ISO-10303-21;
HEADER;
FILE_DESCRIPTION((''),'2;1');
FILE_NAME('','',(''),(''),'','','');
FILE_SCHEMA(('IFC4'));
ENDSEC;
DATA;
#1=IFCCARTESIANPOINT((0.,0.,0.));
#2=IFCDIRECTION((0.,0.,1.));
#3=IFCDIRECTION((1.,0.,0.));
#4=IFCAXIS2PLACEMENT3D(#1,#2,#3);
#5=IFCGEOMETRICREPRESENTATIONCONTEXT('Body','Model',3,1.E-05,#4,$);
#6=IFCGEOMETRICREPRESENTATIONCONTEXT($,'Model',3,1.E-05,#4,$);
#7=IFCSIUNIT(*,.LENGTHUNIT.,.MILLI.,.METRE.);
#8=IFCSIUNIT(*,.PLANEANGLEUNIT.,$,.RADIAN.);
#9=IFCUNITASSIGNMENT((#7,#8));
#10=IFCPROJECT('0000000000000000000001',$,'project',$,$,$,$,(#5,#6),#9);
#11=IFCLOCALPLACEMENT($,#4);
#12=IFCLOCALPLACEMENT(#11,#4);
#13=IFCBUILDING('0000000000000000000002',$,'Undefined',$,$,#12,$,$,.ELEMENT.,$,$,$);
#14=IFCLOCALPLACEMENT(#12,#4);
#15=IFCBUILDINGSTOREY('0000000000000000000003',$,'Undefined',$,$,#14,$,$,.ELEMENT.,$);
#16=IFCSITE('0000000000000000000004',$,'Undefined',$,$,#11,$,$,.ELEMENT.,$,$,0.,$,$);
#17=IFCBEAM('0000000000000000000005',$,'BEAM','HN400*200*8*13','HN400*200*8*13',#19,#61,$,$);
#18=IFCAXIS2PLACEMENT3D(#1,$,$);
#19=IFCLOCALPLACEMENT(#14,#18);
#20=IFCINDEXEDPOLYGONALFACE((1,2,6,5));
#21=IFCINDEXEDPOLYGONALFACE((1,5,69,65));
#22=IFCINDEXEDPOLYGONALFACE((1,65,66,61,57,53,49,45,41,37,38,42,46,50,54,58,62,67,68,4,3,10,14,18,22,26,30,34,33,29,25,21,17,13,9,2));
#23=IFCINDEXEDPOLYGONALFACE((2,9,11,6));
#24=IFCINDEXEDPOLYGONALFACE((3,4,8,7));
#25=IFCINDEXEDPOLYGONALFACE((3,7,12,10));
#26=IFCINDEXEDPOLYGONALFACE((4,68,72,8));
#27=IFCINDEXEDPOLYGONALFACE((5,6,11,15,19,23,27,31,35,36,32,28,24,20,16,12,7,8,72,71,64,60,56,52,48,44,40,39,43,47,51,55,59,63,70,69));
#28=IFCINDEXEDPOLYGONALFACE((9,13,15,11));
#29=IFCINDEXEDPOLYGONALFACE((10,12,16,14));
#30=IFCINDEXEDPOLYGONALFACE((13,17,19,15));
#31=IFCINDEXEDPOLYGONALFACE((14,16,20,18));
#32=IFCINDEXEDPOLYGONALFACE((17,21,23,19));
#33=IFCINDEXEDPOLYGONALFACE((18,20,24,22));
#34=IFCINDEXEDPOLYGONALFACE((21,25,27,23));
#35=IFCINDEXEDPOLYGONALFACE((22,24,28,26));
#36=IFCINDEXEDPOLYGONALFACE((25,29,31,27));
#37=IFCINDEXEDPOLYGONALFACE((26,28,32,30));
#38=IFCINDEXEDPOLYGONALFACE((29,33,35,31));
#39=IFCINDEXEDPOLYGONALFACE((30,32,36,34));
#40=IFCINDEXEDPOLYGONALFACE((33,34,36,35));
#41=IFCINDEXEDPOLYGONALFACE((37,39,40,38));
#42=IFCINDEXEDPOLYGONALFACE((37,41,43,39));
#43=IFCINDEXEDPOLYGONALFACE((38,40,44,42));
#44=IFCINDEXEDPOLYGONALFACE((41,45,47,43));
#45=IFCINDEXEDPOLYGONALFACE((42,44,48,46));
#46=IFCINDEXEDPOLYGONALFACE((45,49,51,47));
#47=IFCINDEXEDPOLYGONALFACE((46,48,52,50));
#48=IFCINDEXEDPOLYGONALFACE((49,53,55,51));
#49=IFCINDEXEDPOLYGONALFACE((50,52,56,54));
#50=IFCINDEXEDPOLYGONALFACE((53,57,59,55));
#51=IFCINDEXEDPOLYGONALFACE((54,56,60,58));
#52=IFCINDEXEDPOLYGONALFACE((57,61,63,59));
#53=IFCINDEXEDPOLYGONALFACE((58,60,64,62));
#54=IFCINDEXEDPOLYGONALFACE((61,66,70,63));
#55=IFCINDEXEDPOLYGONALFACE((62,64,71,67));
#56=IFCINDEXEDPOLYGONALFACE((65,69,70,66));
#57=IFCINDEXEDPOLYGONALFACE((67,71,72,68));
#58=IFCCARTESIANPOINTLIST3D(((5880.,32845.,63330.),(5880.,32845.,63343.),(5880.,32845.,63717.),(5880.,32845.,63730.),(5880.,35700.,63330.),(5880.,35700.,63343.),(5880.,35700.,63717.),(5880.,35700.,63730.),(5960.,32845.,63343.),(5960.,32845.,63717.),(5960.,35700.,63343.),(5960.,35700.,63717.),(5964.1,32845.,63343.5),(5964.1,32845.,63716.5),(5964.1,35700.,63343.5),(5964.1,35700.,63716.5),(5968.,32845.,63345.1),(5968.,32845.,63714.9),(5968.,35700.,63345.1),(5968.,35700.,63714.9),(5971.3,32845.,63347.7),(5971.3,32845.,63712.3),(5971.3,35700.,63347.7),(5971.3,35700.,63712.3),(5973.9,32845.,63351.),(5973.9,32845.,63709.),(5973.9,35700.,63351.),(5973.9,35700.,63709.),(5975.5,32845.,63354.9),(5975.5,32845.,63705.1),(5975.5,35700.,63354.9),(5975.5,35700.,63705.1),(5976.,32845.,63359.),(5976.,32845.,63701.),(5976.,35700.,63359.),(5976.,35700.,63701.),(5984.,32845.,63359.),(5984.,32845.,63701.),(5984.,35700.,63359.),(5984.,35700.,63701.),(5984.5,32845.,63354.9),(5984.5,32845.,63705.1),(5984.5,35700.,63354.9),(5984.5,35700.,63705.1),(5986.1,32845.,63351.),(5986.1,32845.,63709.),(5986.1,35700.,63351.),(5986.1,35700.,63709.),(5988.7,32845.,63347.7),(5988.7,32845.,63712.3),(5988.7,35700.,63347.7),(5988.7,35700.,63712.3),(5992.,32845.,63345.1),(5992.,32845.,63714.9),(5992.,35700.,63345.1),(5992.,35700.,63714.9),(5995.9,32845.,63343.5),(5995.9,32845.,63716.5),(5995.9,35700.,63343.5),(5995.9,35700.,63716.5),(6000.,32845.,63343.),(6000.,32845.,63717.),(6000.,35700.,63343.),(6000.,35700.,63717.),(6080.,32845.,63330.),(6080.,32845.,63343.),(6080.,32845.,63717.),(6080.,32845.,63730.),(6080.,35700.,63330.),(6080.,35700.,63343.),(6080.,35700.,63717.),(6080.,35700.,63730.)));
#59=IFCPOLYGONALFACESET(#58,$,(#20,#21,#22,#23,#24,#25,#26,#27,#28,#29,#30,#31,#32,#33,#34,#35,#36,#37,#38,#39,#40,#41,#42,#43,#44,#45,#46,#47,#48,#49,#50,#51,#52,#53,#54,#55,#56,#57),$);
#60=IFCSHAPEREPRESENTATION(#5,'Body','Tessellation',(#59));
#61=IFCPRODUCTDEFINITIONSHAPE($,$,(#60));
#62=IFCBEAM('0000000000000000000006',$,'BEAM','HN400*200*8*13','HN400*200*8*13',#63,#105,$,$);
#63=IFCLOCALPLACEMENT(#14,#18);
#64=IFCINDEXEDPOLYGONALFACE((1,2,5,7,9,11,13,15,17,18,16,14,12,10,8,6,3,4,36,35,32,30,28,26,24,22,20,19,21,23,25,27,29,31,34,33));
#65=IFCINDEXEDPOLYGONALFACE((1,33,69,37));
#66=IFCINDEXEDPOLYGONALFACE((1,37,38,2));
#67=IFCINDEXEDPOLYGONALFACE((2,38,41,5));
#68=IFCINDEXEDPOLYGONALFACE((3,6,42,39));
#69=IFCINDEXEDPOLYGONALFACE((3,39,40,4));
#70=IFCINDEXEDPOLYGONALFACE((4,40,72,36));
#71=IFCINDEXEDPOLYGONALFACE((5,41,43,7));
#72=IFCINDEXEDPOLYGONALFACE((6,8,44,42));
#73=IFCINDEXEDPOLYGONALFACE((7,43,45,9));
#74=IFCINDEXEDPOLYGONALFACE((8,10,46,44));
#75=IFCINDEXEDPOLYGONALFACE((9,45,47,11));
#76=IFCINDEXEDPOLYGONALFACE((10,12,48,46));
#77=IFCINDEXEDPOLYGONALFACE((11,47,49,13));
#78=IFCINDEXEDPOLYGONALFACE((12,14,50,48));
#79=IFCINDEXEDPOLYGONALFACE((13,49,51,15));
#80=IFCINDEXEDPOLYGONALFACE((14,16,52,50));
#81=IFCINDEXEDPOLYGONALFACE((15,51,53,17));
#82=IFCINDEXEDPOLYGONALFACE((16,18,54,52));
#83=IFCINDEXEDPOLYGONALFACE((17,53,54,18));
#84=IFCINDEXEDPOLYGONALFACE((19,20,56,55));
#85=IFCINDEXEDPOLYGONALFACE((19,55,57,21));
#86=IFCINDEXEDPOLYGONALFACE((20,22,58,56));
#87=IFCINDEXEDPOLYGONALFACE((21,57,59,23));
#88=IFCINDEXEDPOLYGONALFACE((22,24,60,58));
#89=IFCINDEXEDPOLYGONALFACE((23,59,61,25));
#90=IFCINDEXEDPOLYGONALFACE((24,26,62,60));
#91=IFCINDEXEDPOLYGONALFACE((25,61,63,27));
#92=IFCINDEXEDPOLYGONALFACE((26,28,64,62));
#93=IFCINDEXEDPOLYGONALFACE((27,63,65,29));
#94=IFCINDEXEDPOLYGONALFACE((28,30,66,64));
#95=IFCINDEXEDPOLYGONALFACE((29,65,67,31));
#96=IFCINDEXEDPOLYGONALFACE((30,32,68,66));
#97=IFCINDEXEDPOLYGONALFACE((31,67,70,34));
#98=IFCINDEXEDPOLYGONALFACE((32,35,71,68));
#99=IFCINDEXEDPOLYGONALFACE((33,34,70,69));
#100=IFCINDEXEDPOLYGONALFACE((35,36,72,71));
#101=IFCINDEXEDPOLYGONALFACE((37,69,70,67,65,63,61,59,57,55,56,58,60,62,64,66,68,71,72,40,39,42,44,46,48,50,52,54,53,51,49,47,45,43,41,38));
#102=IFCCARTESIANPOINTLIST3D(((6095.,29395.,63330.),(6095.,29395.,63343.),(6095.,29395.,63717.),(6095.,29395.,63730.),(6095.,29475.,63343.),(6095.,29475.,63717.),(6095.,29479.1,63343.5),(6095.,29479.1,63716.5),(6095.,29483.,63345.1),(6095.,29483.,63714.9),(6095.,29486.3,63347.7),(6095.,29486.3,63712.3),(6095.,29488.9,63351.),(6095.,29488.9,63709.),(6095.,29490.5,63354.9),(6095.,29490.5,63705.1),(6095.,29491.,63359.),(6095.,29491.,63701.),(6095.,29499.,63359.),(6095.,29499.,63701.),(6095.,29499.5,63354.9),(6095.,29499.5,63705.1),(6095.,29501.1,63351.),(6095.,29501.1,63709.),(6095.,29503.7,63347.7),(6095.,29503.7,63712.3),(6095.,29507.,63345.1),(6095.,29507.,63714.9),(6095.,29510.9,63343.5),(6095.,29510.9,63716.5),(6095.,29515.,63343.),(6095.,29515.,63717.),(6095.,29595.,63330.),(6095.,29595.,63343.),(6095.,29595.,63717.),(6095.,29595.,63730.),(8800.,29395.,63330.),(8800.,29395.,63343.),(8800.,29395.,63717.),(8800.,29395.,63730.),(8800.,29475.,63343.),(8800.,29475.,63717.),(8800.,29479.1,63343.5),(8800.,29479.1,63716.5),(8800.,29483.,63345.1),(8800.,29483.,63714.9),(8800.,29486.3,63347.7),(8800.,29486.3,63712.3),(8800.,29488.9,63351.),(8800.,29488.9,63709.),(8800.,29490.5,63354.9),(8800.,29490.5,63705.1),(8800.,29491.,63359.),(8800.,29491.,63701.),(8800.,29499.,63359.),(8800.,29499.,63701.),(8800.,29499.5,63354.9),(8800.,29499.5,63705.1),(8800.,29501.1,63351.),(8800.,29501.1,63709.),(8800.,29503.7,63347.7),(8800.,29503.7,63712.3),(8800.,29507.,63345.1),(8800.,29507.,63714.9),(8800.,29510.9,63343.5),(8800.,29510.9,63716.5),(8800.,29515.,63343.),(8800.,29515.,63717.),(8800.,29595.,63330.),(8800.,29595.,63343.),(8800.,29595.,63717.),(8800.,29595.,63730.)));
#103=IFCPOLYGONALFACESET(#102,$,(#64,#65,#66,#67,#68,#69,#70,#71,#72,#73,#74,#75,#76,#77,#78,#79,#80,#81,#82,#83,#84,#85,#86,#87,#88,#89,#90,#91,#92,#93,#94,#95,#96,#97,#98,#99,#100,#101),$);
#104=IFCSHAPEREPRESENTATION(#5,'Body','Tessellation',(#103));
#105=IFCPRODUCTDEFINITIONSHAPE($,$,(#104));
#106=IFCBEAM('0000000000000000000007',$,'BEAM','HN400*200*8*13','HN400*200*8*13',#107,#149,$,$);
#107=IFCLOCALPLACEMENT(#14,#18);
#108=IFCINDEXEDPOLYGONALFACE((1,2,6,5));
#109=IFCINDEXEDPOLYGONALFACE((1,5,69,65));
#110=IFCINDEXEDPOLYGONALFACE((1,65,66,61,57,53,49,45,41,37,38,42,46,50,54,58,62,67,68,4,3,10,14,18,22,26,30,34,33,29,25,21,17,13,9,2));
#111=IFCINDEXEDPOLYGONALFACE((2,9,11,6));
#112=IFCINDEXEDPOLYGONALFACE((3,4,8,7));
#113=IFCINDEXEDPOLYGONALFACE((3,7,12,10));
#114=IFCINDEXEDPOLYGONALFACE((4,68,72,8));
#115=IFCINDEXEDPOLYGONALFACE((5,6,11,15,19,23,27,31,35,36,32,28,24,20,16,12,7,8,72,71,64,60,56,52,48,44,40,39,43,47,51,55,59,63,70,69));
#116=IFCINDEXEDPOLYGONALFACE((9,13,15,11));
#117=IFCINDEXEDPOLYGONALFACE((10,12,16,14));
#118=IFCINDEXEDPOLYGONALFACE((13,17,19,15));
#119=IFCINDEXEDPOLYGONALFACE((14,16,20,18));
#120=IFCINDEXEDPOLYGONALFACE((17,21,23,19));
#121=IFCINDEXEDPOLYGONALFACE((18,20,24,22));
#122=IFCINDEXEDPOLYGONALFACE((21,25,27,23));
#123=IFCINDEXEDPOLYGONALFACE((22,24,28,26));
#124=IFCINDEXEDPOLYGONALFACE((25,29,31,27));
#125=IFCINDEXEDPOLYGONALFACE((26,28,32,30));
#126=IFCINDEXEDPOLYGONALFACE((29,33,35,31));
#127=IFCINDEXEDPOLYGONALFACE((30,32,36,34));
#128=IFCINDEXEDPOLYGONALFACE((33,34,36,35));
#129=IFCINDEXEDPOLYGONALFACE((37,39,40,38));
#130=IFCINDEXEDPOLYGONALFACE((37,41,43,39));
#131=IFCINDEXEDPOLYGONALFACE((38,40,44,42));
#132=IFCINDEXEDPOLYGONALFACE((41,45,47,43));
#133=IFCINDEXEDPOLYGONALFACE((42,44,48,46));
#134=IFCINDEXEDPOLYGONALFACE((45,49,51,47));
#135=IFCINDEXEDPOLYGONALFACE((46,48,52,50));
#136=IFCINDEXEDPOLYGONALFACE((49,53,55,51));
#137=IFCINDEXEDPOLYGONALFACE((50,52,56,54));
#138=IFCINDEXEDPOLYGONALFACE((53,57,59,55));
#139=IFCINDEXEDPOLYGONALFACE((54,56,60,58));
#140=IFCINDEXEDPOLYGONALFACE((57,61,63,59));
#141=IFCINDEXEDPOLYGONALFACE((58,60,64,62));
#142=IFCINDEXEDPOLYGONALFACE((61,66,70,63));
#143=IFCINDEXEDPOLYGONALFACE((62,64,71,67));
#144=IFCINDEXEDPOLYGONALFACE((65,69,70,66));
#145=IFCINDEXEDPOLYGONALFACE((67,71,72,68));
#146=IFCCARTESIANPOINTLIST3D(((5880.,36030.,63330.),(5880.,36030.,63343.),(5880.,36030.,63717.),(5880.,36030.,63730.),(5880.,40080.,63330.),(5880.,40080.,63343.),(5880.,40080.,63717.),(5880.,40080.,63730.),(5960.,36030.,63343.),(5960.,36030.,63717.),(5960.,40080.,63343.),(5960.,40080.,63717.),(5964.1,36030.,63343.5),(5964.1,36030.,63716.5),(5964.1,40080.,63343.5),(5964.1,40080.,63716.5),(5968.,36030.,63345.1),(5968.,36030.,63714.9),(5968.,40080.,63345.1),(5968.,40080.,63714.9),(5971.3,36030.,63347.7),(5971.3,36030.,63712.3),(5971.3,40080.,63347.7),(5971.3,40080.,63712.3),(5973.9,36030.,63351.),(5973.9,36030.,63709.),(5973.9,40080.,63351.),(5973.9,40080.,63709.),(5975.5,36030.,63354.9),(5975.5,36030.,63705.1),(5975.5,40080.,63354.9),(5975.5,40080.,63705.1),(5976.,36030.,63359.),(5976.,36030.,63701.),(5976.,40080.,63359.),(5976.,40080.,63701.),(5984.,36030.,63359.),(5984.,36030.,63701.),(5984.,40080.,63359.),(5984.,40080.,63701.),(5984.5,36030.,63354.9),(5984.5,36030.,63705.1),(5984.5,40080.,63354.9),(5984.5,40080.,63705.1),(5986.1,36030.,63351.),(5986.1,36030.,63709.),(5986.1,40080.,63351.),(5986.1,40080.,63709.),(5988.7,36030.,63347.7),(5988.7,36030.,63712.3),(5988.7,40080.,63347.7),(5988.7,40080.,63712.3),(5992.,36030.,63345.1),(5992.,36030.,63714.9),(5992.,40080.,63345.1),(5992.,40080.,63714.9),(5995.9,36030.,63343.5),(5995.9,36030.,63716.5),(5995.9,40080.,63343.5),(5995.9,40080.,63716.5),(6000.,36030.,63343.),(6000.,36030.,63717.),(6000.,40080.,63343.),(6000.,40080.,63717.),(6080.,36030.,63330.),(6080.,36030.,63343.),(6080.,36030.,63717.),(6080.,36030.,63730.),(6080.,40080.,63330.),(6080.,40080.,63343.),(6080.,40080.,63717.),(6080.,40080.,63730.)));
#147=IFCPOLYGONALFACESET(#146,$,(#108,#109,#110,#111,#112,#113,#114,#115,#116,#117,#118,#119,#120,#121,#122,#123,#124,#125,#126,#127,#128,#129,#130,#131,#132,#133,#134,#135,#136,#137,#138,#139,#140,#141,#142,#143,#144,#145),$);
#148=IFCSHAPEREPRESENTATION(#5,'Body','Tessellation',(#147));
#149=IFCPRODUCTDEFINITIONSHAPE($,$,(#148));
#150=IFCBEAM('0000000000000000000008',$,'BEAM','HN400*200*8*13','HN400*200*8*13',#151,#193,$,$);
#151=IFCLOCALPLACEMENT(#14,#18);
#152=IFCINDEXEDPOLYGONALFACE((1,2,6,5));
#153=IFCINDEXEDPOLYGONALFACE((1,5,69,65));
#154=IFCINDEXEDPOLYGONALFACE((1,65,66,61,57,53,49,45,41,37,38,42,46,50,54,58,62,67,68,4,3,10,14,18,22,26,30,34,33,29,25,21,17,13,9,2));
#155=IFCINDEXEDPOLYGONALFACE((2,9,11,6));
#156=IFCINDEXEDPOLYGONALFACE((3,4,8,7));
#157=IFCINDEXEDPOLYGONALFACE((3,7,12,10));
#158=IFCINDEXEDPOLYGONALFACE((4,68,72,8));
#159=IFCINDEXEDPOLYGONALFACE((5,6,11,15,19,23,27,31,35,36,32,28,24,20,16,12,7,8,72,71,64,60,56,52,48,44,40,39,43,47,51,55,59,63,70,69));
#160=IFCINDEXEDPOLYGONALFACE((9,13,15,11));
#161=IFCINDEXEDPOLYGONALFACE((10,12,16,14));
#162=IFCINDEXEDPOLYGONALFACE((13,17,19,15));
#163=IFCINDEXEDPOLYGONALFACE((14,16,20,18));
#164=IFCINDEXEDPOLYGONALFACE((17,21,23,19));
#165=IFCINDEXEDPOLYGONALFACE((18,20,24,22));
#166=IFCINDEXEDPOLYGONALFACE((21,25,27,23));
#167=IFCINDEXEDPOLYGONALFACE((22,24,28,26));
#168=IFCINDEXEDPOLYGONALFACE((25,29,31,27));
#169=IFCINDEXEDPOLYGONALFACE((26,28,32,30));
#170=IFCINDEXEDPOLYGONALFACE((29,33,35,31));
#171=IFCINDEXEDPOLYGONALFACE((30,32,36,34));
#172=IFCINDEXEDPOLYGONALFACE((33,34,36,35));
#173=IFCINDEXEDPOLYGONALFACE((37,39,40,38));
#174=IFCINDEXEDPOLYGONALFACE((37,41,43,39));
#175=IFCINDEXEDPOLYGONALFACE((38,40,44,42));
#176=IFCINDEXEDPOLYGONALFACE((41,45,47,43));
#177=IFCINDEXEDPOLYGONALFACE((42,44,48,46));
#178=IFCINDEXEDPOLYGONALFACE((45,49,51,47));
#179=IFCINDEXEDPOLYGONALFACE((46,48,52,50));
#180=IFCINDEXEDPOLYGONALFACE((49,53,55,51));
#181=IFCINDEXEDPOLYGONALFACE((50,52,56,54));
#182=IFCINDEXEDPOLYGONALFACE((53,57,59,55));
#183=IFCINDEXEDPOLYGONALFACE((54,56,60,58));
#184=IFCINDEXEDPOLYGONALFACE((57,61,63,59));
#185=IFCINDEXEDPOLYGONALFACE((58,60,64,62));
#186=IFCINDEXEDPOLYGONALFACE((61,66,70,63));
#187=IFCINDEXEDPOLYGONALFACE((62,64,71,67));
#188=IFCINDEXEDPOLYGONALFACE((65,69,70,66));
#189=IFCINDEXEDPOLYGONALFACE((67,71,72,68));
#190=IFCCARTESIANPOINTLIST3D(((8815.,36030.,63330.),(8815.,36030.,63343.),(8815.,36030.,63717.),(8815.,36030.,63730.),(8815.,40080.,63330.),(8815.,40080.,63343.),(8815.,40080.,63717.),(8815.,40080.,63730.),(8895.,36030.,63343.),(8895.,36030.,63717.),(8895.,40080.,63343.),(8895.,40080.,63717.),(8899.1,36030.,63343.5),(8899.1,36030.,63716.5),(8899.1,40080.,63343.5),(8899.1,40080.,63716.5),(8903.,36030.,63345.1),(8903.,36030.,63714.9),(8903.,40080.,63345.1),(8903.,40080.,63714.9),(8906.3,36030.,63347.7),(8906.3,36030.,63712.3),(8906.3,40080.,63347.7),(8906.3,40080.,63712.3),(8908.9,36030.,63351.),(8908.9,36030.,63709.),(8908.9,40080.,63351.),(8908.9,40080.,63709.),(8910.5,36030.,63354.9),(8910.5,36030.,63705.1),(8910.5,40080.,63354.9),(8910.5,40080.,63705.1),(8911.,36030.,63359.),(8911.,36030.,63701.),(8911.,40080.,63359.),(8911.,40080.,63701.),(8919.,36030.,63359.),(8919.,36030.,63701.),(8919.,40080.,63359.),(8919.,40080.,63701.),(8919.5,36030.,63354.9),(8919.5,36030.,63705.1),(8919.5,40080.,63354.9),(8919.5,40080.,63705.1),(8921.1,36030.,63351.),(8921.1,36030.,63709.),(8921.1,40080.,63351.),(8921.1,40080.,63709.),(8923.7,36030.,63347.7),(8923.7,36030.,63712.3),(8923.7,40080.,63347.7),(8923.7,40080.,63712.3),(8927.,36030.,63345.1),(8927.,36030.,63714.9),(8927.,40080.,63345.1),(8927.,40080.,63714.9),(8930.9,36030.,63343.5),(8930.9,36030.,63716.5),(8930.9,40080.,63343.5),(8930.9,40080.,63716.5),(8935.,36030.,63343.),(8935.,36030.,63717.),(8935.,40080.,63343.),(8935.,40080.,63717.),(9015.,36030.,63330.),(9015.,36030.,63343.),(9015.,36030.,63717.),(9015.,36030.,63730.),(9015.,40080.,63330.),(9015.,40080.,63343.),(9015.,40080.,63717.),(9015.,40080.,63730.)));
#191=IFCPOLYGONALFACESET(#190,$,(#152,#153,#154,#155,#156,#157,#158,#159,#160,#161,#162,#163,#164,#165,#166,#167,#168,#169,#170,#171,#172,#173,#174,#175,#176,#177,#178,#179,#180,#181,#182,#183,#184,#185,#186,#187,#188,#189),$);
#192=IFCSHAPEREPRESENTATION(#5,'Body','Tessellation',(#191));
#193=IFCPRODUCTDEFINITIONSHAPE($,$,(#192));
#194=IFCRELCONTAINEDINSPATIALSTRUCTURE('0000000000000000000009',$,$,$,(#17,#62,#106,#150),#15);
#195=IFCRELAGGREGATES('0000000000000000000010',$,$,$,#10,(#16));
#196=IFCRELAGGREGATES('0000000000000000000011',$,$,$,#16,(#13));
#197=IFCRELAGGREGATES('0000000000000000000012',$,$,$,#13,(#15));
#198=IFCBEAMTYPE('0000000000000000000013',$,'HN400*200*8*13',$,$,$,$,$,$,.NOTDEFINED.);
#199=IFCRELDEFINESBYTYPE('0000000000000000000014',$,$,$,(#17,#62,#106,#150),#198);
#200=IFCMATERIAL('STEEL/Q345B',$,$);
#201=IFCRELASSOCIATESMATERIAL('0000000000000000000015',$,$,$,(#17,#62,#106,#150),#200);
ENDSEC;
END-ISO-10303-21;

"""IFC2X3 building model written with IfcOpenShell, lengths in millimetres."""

from ifc_helpers import new_model, si_unit, frame, origin_with_axes, origin_2d_with_axis, place, context, project, spatial, i_section, extrude, material, type_object, element, save


model = new_model("IFC2X3")

# Units and contexts
model_context_1 = context("Model", 3, precision=1e-05, world=origin_with_axes(), identifier="Body")
model_context_2 = context("Model", 3, precision=1e-05, world=origin_with_axes())
ifc_project = project(units=[si_unit("LENGTHUNIT", "METRE", prefix="MILLI"), si_unit("PLANEANGLEUNIT", "RADIAN")], contexts=[model_context_1, model_context_2])

# Site, building, storey
site_placement = place(None, origin_with_axes())
site = spatial("IfcSite", under=ifc_project, at=site_placement, Name="Undefined", CompositionType="ELEMENT", RefElevation=0.0)
building_placement = place(site_placement, origin_with_axes())
building = spatial("IfcBuilding", under=site, at=building_placement, Name="Undefined", CompositionType="ELEMENT")
storey_placement = place(building_placement, origin_with_axes())
storey = spatial("IfcBuildingStorey", under=building, at=storey_placement, Name="Undefined", CompositionType="ELEMENT")

# Shared definitions
ifc_material_1 = material(Name="STEEL/Q345B")

# Beams
beam_type_1 = type_object("IfcBeamType", Name="HN400*200*8*13", PredefinedType="NOTDEFINED")
for number, where, z_axis, x_axis, name in (
    (1, (5980.0, 32680.0, 63530.0), (0.0, 0.0, 1.0), (0.0, 1.0, 0.0), "BEAM"),
):
    element("IfcBeam", number, at=place(storey_placement, frame(where, z_axis=z_axis, x_axis=x_axis)), inside=storey, type_object=beam_type_1, material=ifc_material_1, Name=name, Description="HN400*200*8*13", ObjectType="HN400*200*8*13", context=model_context_1, shape_type="SweptSolid", body=[
        extrude(i_section(OverallWidth=200.0, OverallDepth=400.0, WebThickness=8.0, FlangeThickness=13.0, FilletRadius=16.0, at=origin_2d_with_axis()), frame((3020.0, 0.0, 0.0), z_axis=(-1.0, 0.0, 0.0), x_axis=(0.0, -1.0, 0.0)), (0.0, 0.0, 1.0), 2855.0),
    ])
beam_1_placement = place(storey_placement, frame((8915.0, 29495.0, 63530.0), z_axis=(0.0, 0.0, 1.0), x_axis=(-1.0, 0.0, 0.0)))
element("IfcBeam", 2, at=beam_1_placement, inside=storey, type_object=beam_type_1, material=ifc_material_1, Name="BEAM", Description="HN400*200*8*13", ObjectType="HN400*200*8*13", context=model_context_1, shape_type="SweptSolid", body=[
    extrude(i_section(OverallWidth=200.0, OverallDepth=400.0, WebThickness=8.0, FlangeThickness=13.0, FilletRadius=16.0, at=origin_2d_with_axis()), frame((2820.0, 0.0, 0.0), z_axis=(-1.0, 0.0, 0.0), x_axis=(0.0, -1.0, 0.0)), (0.0, 0.0, 1.0), 2705.0),
])
beam_2_placement = place(storey_placement, frame((5980.0, 35621.2, 63530.0), z_axis=(0.0, 0.0, 1.0), x_axis=(0.0, 1.0, 0.0)))
element("IfcBeam", 3, at=beam_2_placement, inside=storey, type_object=beam_type_1, material=ifc_material_1, Name="BEAM", Description="HN400*200*8*13", ObjectType="HN400*200*8*13", context=model_context_1, shape_type="SweptSolid", body=[
    extrude(i_section(OverallWidth=200.0, OverallDepth=400.0, WebThickness=8.0, FlangeThickness=13.0, FilletRadius=16.0, at=origin_2d_with_axis()), frame((4458.8, 0.0, 0.0), z_axis=(-1.0, 0.0, 0.0), x_axis=(0.0, -1.0, 0.0)), (0.0, 0.0, 1.0), 4050.0),
])
beam_3_placement = place(storey_placement, frame((8915.0, 35651.8, 63530.0), z_axis=(0.0, 0.0, 1.0), x_axis=(0.0, 1.0, 0.0)))
element("IfcBeam", 4, at=beam_3_placement, inside=storey, type_object=beam_type_1, material=ifc_material_1, Name="BEAM", Description="HN400*200*8*13", ObjectType="HN400*200*8*13", context=model_context_1, shape_type="SweptSolid", body=[
    extrude(i_section(OverallWidth=200.0, OverallDepth=400.0, WebThickness=8.0, FlangeThickness=13.0, FilletRadius=16.0, at=origin_2d_with_axis()), frame((4428.2, 0.0, 0.0), z_axis=(-1.0, 0.0, 0.0), x_axis=(0.0, -1.0, 0.0)), (0.0, 0.0, 1.0), 4050.0),
])

save(model, "model.ifc")
